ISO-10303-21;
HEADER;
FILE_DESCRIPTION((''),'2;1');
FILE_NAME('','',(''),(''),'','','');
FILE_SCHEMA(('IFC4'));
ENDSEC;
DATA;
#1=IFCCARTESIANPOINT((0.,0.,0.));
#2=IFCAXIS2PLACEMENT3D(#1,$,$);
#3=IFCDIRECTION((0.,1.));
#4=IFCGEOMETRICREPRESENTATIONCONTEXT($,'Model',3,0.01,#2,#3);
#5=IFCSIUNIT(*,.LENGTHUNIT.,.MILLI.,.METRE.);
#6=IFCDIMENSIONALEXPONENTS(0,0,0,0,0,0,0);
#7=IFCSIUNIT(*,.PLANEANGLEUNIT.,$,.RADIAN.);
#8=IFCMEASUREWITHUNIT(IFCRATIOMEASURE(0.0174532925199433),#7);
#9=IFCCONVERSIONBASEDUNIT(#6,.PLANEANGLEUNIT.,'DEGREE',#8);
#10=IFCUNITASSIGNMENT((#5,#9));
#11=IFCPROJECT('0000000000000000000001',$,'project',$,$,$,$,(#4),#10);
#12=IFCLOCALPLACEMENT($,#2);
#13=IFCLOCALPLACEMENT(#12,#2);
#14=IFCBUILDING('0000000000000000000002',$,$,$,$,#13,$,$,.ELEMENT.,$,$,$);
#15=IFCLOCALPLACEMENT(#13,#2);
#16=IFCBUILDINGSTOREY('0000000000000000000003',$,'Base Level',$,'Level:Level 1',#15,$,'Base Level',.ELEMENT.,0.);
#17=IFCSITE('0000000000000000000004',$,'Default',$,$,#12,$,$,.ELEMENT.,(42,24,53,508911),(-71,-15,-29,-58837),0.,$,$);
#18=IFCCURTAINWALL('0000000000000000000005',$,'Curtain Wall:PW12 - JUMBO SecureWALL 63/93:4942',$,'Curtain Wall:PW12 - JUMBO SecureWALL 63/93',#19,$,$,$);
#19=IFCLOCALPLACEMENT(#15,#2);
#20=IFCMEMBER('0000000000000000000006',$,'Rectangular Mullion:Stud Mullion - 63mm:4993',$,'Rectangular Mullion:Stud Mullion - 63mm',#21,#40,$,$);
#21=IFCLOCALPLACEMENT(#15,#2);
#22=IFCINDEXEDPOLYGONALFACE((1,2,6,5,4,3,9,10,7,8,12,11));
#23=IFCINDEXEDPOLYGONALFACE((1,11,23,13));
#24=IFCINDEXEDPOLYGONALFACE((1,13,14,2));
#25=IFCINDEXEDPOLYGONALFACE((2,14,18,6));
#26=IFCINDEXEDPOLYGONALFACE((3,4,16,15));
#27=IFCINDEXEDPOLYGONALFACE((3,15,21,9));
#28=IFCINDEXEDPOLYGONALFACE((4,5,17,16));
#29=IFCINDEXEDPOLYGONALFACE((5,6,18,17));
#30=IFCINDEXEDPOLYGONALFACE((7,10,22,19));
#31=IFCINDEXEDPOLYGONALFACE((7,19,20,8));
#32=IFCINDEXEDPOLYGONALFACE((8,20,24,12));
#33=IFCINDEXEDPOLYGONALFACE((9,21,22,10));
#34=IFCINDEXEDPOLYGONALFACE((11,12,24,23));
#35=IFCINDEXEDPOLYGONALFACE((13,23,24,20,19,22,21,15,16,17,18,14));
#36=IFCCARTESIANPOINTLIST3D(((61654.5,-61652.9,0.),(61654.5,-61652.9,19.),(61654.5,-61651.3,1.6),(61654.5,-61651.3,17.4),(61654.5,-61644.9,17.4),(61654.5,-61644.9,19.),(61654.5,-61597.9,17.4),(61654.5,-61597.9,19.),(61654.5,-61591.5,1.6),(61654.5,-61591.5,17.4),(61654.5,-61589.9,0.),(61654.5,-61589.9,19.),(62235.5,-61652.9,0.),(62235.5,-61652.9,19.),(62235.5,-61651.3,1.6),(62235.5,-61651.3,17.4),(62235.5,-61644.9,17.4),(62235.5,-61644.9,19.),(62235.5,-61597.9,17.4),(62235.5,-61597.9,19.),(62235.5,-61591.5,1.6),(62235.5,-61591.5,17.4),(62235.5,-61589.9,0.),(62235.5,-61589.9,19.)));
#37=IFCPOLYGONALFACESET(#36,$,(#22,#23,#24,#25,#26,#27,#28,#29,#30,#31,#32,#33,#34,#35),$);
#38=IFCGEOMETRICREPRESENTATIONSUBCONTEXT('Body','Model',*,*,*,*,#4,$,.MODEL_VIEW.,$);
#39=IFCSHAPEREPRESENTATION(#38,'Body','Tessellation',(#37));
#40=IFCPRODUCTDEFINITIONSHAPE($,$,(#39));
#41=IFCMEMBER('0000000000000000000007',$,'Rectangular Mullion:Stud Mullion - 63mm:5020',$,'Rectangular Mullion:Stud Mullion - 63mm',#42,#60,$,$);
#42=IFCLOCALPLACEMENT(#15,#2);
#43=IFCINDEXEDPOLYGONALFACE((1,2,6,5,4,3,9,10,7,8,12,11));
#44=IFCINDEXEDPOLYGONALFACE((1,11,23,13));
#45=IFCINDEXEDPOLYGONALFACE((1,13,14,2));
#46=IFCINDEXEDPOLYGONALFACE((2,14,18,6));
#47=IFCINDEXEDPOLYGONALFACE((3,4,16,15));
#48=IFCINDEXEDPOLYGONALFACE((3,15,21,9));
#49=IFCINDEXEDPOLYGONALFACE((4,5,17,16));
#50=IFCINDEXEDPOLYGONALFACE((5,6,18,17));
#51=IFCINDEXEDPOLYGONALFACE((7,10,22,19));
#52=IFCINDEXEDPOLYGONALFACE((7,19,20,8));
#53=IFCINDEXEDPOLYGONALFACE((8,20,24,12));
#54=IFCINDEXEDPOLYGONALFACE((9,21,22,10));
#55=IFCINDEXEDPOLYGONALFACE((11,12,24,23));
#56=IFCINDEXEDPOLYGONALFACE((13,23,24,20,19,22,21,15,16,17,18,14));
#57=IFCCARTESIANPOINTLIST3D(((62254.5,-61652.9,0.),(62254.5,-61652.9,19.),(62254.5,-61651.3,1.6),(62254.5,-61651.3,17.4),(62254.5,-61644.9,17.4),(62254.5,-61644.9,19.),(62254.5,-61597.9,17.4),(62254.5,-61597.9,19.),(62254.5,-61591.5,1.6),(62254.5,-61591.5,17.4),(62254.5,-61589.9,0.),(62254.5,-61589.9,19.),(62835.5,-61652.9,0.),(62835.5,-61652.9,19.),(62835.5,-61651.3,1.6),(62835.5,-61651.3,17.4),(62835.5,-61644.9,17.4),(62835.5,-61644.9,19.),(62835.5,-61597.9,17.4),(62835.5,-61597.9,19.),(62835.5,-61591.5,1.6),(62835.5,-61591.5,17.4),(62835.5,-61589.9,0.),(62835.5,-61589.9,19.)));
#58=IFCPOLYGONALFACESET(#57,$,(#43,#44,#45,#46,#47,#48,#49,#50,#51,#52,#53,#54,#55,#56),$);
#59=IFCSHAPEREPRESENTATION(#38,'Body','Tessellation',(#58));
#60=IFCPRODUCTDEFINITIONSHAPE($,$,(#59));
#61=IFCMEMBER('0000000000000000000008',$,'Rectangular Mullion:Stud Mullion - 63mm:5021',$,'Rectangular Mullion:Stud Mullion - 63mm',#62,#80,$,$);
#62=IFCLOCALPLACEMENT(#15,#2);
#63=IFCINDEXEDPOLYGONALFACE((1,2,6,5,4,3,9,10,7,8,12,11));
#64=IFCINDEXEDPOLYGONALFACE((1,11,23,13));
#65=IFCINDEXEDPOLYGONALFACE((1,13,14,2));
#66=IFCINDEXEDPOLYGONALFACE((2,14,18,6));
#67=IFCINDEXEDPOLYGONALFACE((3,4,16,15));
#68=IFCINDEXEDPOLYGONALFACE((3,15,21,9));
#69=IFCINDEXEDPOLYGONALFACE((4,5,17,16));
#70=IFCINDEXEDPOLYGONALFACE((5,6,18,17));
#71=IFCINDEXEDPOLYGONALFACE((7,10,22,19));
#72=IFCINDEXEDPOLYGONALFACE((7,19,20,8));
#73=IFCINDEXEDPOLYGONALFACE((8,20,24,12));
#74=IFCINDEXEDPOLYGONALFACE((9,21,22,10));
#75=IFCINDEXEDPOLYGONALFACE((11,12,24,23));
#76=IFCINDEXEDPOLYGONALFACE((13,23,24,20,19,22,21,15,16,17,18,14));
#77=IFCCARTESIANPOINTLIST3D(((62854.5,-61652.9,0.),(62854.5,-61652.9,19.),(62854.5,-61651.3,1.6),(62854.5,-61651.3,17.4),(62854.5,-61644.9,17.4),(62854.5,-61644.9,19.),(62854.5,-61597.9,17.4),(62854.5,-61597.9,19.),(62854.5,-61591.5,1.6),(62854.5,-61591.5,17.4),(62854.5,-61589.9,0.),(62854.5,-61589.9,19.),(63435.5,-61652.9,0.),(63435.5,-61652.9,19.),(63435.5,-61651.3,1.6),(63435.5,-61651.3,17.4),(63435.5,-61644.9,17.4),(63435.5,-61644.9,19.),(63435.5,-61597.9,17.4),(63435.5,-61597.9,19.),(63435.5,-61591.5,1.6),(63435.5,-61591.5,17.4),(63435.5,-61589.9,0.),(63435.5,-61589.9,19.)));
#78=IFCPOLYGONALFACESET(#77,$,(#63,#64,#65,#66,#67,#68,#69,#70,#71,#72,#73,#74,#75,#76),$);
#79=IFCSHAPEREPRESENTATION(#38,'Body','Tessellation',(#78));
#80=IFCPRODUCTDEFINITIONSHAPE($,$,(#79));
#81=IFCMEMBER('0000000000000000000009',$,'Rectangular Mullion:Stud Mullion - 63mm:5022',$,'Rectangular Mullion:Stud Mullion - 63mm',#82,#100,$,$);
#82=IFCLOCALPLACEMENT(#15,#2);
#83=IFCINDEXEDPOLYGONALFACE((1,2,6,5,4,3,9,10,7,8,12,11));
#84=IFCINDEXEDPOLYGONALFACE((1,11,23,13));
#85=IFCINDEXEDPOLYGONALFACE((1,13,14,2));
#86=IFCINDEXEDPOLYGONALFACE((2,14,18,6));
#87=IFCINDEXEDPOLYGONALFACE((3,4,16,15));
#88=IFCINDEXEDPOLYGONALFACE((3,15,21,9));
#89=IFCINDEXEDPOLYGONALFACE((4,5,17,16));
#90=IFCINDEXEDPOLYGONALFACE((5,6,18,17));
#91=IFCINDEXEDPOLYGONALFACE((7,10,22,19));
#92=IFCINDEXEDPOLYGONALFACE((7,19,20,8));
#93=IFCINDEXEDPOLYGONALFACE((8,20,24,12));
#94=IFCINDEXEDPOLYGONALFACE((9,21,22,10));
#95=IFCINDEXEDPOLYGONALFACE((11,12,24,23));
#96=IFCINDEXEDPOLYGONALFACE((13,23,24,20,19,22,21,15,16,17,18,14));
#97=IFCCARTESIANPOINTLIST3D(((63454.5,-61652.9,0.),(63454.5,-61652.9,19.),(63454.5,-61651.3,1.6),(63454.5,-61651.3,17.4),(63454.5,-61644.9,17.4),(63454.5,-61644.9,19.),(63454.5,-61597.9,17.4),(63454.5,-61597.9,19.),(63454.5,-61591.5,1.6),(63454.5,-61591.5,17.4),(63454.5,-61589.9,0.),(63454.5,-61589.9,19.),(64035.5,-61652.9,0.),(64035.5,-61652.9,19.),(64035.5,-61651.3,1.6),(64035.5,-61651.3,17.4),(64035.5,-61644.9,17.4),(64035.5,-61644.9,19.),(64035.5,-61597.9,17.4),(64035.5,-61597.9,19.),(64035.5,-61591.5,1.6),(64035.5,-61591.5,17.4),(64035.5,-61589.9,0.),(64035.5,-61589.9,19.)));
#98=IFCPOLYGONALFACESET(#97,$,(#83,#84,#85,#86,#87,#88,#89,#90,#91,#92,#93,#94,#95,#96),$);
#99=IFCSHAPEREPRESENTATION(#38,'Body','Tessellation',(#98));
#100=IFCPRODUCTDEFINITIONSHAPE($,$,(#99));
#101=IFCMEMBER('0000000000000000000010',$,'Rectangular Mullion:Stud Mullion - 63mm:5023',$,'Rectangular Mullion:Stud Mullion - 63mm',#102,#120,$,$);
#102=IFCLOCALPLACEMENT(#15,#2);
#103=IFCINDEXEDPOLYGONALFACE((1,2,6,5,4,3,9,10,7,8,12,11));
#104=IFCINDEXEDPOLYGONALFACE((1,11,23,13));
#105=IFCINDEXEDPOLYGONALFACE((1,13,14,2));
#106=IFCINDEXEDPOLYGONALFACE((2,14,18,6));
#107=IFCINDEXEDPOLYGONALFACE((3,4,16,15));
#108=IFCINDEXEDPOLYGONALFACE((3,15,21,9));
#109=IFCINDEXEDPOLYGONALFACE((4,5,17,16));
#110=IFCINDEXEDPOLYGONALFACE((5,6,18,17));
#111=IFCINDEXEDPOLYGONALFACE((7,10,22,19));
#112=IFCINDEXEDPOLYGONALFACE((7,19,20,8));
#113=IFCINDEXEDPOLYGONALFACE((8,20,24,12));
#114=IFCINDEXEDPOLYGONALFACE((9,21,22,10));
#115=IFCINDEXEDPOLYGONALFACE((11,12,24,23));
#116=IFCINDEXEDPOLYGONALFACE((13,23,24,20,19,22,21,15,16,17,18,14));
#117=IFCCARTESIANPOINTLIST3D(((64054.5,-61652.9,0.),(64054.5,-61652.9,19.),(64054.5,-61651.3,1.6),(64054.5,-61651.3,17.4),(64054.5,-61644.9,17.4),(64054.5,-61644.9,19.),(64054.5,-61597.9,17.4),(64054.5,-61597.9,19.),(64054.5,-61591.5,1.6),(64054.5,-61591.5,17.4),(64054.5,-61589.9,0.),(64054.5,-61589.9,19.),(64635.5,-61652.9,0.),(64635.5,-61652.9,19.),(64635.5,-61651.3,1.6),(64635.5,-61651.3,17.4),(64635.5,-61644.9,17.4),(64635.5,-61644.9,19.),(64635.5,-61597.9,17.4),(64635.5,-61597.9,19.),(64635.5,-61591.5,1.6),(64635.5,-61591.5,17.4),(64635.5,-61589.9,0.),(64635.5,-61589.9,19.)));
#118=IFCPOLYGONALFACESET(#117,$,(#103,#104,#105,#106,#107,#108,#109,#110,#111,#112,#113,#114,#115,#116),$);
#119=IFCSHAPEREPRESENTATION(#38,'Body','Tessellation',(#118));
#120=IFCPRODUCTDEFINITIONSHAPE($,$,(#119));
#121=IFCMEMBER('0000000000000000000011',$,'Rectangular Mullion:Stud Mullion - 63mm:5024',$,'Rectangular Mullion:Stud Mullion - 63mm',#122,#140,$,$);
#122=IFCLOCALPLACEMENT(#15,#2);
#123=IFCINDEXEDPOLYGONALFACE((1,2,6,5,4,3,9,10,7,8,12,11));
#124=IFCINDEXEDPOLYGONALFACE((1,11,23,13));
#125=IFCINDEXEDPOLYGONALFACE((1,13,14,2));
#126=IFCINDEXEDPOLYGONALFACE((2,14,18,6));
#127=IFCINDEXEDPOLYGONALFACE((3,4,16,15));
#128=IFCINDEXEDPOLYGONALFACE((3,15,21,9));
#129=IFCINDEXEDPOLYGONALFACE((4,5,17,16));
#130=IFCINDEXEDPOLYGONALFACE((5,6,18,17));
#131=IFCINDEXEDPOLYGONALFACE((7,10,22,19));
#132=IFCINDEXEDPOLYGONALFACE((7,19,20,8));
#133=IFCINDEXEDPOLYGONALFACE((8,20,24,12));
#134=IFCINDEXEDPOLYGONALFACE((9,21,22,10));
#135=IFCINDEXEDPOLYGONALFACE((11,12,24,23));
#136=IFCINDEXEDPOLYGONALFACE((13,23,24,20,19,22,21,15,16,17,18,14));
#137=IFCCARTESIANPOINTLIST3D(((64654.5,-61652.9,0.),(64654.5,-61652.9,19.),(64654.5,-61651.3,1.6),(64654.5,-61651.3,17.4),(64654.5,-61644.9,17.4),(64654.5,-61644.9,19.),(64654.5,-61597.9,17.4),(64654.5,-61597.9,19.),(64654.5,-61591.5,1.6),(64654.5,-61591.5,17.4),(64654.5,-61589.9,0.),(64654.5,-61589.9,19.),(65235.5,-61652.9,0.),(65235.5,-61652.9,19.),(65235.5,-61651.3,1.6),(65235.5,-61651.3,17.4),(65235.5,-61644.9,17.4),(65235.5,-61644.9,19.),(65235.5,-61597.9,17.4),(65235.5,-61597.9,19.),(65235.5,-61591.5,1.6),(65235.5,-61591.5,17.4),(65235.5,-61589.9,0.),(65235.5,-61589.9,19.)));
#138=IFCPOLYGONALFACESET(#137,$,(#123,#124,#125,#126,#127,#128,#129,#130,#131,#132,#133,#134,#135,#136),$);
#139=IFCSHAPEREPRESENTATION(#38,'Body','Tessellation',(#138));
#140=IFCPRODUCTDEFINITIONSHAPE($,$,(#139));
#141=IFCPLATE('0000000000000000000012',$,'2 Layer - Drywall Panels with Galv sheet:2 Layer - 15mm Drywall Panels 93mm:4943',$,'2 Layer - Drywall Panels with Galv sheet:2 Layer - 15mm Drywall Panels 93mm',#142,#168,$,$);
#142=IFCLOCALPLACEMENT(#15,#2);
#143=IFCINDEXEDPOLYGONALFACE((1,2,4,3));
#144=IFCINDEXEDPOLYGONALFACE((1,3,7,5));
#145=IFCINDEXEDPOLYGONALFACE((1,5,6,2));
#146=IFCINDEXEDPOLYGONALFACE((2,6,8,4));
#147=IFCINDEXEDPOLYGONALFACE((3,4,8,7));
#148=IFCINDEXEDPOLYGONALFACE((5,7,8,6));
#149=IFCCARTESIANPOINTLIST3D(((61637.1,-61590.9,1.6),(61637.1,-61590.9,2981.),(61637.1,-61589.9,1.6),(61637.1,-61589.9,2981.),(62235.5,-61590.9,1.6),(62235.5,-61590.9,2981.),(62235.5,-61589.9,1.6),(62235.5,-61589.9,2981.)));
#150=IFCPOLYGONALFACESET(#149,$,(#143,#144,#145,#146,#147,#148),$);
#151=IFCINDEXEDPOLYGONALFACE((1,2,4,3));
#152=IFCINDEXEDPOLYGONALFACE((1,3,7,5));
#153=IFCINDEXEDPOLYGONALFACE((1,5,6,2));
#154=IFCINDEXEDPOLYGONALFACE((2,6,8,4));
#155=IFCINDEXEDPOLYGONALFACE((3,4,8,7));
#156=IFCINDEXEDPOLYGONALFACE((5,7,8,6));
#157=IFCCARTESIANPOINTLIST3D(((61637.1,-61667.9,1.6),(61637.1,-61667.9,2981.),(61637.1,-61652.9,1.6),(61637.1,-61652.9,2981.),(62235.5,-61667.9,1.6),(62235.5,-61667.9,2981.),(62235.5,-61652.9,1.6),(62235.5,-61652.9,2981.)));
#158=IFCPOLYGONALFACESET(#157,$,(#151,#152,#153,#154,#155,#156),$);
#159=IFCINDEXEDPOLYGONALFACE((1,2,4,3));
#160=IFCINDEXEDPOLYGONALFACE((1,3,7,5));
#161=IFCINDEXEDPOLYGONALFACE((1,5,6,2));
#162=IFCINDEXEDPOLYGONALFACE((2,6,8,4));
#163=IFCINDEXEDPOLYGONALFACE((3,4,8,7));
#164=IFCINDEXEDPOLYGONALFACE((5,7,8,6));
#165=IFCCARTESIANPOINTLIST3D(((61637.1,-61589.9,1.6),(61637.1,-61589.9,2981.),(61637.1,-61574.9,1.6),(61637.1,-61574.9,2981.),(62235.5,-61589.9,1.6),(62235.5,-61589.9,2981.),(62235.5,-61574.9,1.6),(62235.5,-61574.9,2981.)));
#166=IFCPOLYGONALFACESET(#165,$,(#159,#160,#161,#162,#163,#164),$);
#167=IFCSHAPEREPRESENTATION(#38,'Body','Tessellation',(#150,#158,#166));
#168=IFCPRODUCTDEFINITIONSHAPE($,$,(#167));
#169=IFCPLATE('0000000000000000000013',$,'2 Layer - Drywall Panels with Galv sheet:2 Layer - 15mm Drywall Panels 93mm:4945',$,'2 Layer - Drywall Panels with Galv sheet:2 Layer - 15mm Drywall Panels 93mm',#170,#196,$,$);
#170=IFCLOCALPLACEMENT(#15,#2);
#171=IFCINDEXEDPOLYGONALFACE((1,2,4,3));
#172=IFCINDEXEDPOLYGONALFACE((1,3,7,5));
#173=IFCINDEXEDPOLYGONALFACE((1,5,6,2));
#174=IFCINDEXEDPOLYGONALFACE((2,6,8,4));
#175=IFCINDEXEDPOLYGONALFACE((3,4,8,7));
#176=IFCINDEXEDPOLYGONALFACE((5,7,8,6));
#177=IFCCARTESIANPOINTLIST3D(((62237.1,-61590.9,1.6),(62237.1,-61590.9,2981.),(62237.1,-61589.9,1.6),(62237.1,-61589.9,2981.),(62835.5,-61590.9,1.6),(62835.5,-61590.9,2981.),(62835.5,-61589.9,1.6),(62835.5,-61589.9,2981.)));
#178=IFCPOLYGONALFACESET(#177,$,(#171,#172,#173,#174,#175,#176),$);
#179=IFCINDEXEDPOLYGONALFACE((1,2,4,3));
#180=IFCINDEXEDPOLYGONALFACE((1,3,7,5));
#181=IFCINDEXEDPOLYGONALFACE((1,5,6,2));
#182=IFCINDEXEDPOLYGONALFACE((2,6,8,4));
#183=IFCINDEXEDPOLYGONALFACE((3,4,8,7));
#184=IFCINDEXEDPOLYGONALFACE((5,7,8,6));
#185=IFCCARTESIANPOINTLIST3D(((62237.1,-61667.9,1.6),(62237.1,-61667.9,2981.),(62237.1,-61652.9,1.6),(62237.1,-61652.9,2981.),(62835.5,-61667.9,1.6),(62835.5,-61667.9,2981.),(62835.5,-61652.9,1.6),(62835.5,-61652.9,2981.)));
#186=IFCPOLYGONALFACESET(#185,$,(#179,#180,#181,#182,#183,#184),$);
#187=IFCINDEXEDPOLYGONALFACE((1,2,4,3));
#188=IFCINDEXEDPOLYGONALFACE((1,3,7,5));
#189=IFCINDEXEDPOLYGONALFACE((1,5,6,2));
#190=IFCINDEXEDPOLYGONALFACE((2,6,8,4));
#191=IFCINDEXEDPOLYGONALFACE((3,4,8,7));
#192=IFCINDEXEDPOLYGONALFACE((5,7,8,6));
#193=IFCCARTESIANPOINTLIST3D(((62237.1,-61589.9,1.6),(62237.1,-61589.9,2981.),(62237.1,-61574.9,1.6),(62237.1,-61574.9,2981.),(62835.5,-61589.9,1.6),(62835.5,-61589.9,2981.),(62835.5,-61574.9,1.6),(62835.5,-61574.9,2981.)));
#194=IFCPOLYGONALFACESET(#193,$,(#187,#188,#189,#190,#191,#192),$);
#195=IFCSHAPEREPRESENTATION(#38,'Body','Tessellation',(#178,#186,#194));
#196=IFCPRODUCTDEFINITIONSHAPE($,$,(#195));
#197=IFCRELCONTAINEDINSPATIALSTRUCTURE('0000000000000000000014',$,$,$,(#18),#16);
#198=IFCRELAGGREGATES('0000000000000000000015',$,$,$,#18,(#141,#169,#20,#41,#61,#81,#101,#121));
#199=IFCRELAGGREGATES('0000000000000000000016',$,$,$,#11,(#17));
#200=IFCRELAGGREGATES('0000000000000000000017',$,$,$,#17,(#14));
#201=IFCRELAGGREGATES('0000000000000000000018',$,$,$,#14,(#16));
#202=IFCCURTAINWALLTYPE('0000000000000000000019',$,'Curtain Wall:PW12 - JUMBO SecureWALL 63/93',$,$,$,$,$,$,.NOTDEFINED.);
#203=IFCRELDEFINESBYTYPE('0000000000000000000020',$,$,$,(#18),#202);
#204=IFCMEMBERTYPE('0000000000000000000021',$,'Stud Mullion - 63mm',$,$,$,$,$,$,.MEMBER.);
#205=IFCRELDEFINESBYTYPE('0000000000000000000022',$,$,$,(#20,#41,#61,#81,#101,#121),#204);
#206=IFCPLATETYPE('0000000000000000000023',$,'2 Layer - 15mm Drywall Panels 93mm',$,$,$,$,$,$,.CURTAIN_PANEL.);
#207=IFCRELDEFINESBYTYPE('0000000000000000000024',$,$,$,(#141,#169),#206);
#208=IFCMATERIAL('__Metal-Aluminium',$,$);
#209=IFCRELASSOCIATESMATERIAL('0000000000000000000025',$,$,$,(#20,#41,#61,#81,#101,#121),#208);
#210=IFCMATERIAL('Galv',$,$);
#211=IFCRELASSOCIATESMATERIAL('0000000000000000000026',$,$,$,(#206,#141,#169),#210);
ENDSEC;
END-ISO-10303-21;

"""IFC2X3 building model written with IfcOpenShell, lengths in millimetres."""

from ifc_helpers import new_model, entity, si_unit, converted_unit, direction, frame, frame_2d, origin, origin_2d_with_axis, place, context, subcontext, project, spatial, polyline, rectangle, outline, extrude, source, transform, mapped, material, type_object, type_shapes, element, aggregate, save


model = new_model("IFC2X3")

# Units and contexts
model_context = context("Model", 3, precision=0.01, world=origin(), true_north=direction((0.0, 1.0)))
body_context = subcontext(model_context, "Body", "Model", "MODEL_VIEW")
ifc_project = project(units=[si_unit("LENGTHUNIT", "METRE", prefix="MILLI"), converted_unit("PLANEANGLEUNIT", "DEGREE", entity("IfcRatioMeasure", 0.0174532925199433), si_unit("PLANEANGLEUNIT", "RADIAN"), dimensions=[0, 0, 0, 0, 0, 0, 0])], contexts=[model_context])

# Site, building, storey
site_placement = place(None, origin())
site = spatial("IfcSite", under=ifc_project, at=site_placement, Name="Default", CompositionType="ELEMENT", RefLatitude=(42, 24, 53, 508911), RefLongitude=(-71, -15, -29, -58837), RefElevation=0.0)
building_placement = place(site_placement, origin())
building = spatial("IfcBuilding", under=site, at=building_placement, CompositionType="ELEMENT")
storey_placement = place(building_placement, origin())
storey = spatial("IfcBuildingStorey", under=building, at=storey_placement, Name="Base Level", ObjectType="Level:Level 1", LongName="Base Level", CompositionType="ELEMENT", Elevation=0.0)

# Curtain wall, members, plates
curtain_wall_type = type_object("IfcCurtainWallType", Name="Curtain Wall:PW12 - JUMBO SecureWALL 63/93", PredefinedType="NOTDEFINED")
curtain_wall_placement = place(building_placement, origin())
curtain_wall = element("IfcCurtainWall", 1, at=curtain_wall_placement, inside=storey, type_object=curtain_wall_type, Name="Curtain Wall:PW12 - JUMBO SecureWALL 63/93:4942", ObjectType="Curtain Wall:PW12 - JUMBO SecureWALL 63/93")
ifc_material_1 = material(Name="__Metal-Aluminium")
member_type_1 = type_object("IfcMemberType", Name="Stud Mullion - 63mm", PredefinedType="MEMBER")
shared_shape_1 = source(origin(), body_context, "Body", "SweptSolid", [
    extrude(outline(polyline([(23.5, -6.6), (31.5, -6.6), (31.5, 12.4), (-31.5, 12.4), (-31.5, -6.6), (-23.5, -6.6), (-23.5, -5.0), (-29.9, -5.0), (-29.9, 10.8), (29.9, 10.8), (29.9, -5.0), (23.5, -5.0), (23.5, -6.6)])), frame((-12.4, 0.0, -581.0), z_axis=(0.0, 0.0, 1.0), x_axis=(0.0, -1.0, 0.0)), (0.0, 0.0, 1.0), 581.0),
])
type_shapes(member_type_1, [shared_shape_1])
member_1_placement = place(building_placement, frame((61654.5, -61621.4, 0.0), z_axis=(-1.0, 0.0, 0.0), x_axis=(0.0, 0.0, -1.0)))
member_1 = element("IfcMember", 2, at=member_1_placement, type_object=member_type_1, material=ifc_material_1, Name="Rectangular Mullion:Stud Mullion - 63mm:4993", ObjectType="Rectangular Mullion:Stud Mullion - 63mm", context=body_context, shape_type="MappedRepresentation", body=[
    mapped(shared_shape_1, transform((0.0, 0.0, 0.0), scale=1.0)),
])
member_2_placement = place(building_placement, frame((62254.5, -61621.4, 0.0), z_axis=(-1.0, 0.0, 0.0), x_axis=(0.0, 0.0, -1.0)))
member_2 = element("IfcMember", 3, at=member_2_placement, type_object=member_type_1, material=ifc_material_1, Name="Rectangular Mullion:Stud Mullion - 63mm:5020", ObjectType="Rectangular Mullion:Stud Mullion - 63mm", context=body_context, shape_type="MappedRepresentation", body=[
    mapped(shared_shape_1, transform((0.0, 0.0, 0.0), scale=1.0)),
])
member_3_placement = place(building_placement, frame((62854.5, -61621.4, 0.0), z_axis=(-1.0, 0.0, 0.0), x_axis=(0.0, 0.0, -1.0)))
member_3 = element("IfcMember", 4, at=member_3_placement, type_object=member_type_1, material=ifc_material_1, Name="Rectangular Mullion:Stud Mullion - 63mm:5021", ObjectType="Rectangular Mullion:Stud Mullion - 63mm", context=body_context, shape_type="MappedRepresentation", body=[
    mapped(shared_shape_1, transform((0.0, 0.0, 0.0), scale=1.0)),
])
member_4_placement = place(building_placement, frame((63454.5, -61621.4, 0.0), z_axis=(-1.0, 0.0, 0.0), x_axis=(0.0, 0.0, -1.0)))
member_4 = element("IfcMember", 5, at=member_4_placement, type_object=member_type_1, material=ifc_material_1, Name="Rectangular Mullion:Stud Mullion - 63mm:5022", ObjectType="Rectangular Mullion:Stud Mullion - 63mm", context=body_context, shape_type="MappedRepresentation", body=[
    mapped(shared_shape_1, transform((0.0, 0.0, 0.0), scale=1.0)),
])
member_5_placement = place(building_placement, frame((64054.5, -61621.4, 0.0), z_axis=(-1.0, 0.0, 0.0), x_axis=(0.0, 0.0, -1.0)))
member_5 = element("IfcMember", 6, at=member_5_placement, type_object=member_type_1, material=ifc_material_1, Name="Rectangular Mullion:Stud Mullion - 63mm:5023", ObjectType="Rectangular Mullion:Stud Mullion - 63mm", context=body_context, shape_type="MappedRepresentation", body=[
    mapped(shared_shape_1, transform((0.0, 0.0, 0.0), scale=1.0)),
])
member_6_placement = place(building_placement, frame((64654.5, -61621.4, 0.0), z_axis=(-1.0, 0.0, 0.0), x_axis=(0.0, 0.0, -1.0)))
member_6 = element("IfcMember", 7, at=member_6_placement, type_object=member_type_1, material=ifc_material_1, Name="Rectangular Mullion:Stud Mullion - 63mm:5024", ObjectType="Rectangular Mullion:Stud Mullion - 63mm", context=body_context, shape_type="MappedRepresentation", body=[
    mapped(shared_shape_1, transform((0.0, 0.0, 0.0), scale=1.0)),
])
ifc_material_2 = material(Name="Galv")
plate_type = type_object("IfcPlateType", Name="2 Layer - 15mm Drywall Panels 93mm", PredefinedType="CURTAIN_PANEL", material=ifc_material_2)
shared_shape_2 = source(origin(), body_context, "Body", "SweptSolid", [
    extrude(rectangle(XDim=598.4, YDim=1.0, at=origin_2d_with_axis()), frame((0.0, 31.0, 0.0), z_axis=(0.0, 0.0, 1.0), x_axis=(-1.0, 0.0, 0.0)), (0.0, 0.0, 1.0), 2979.4),
    extrude(rectangle(XDim=598.4, YDim=15.0, at=frame_2d((0.0, 0.0), x_axis=(1.0, 0.0))), frame((0.0, -39.0, 0.0), z_axis=(0.0, 0.0, 1.0), x_axis=(-1.0, 0.0, 0.0)), (0.0, 0.0, 1.0), 2979.4),
    extrude(rectangle(XDim=15.0, YDim=598.4, at=frame_2d((0.0, 0.0), x_axis=(1.0, 0.0))), frame((0.0, 39.0, 0.0), z_axis=(0.0, 0.0, 1.0), x_axis=(0.0, 1.0, 0.0)), (0.0, 0.0, 1.0), 2979.4),
])
type_shapes(plate_type, [shared_shape_2])
plate_1_placement = place(curtain_wall_placement, frame((61936.3, -61621.4, 1.6)))
plate_1 = element("IfcPlate", 8, at=plate_1_placement, type_object=plate_type, material=ifc_material_2, Name="2 Layer - Drywall Panels with Galv sheet:2 Layer - 15mm Drywall Panels 93mm:4943", ObjectType="2 Layer - Drywall Panels with Galv sheet:2 Layer - 15mm Drywall Panels 93mm", context=body_context, shape_type="MappedRepresentation", body=[
    mapped(shared_shape_2, transform((0.0, 0.0, 0.0), scale=1.0)),
])
plate_2_placement = place(curtain_wall_placement, frame((62536.3, -61621.4, 1.6)))
plate_2 = element("IfcPlate", 9, at=plate_2_placement, type_object=plate_type, material=ifc_material_2, Name="2 Layer - Drywall Panels with Galv sheet:2 Layer - 15mm Drywall Panels 93mm:4945", ObjectType="2 Layer - Drywall Panels with Galv sheet:2 Layer - 15mm Drywall Panels 93mm", context=body_context, shape_type="MappedRepresentation", body=[
    mapped(shared_shape_2, transform((0.0, 0.0, 0.0), scale=1.0)),
])
aggregate(curtain_wall, [plate_1, plate_2, member_1, member_2, member_3, member_4, member_5, member_6])

save(model, "model.ifc")
